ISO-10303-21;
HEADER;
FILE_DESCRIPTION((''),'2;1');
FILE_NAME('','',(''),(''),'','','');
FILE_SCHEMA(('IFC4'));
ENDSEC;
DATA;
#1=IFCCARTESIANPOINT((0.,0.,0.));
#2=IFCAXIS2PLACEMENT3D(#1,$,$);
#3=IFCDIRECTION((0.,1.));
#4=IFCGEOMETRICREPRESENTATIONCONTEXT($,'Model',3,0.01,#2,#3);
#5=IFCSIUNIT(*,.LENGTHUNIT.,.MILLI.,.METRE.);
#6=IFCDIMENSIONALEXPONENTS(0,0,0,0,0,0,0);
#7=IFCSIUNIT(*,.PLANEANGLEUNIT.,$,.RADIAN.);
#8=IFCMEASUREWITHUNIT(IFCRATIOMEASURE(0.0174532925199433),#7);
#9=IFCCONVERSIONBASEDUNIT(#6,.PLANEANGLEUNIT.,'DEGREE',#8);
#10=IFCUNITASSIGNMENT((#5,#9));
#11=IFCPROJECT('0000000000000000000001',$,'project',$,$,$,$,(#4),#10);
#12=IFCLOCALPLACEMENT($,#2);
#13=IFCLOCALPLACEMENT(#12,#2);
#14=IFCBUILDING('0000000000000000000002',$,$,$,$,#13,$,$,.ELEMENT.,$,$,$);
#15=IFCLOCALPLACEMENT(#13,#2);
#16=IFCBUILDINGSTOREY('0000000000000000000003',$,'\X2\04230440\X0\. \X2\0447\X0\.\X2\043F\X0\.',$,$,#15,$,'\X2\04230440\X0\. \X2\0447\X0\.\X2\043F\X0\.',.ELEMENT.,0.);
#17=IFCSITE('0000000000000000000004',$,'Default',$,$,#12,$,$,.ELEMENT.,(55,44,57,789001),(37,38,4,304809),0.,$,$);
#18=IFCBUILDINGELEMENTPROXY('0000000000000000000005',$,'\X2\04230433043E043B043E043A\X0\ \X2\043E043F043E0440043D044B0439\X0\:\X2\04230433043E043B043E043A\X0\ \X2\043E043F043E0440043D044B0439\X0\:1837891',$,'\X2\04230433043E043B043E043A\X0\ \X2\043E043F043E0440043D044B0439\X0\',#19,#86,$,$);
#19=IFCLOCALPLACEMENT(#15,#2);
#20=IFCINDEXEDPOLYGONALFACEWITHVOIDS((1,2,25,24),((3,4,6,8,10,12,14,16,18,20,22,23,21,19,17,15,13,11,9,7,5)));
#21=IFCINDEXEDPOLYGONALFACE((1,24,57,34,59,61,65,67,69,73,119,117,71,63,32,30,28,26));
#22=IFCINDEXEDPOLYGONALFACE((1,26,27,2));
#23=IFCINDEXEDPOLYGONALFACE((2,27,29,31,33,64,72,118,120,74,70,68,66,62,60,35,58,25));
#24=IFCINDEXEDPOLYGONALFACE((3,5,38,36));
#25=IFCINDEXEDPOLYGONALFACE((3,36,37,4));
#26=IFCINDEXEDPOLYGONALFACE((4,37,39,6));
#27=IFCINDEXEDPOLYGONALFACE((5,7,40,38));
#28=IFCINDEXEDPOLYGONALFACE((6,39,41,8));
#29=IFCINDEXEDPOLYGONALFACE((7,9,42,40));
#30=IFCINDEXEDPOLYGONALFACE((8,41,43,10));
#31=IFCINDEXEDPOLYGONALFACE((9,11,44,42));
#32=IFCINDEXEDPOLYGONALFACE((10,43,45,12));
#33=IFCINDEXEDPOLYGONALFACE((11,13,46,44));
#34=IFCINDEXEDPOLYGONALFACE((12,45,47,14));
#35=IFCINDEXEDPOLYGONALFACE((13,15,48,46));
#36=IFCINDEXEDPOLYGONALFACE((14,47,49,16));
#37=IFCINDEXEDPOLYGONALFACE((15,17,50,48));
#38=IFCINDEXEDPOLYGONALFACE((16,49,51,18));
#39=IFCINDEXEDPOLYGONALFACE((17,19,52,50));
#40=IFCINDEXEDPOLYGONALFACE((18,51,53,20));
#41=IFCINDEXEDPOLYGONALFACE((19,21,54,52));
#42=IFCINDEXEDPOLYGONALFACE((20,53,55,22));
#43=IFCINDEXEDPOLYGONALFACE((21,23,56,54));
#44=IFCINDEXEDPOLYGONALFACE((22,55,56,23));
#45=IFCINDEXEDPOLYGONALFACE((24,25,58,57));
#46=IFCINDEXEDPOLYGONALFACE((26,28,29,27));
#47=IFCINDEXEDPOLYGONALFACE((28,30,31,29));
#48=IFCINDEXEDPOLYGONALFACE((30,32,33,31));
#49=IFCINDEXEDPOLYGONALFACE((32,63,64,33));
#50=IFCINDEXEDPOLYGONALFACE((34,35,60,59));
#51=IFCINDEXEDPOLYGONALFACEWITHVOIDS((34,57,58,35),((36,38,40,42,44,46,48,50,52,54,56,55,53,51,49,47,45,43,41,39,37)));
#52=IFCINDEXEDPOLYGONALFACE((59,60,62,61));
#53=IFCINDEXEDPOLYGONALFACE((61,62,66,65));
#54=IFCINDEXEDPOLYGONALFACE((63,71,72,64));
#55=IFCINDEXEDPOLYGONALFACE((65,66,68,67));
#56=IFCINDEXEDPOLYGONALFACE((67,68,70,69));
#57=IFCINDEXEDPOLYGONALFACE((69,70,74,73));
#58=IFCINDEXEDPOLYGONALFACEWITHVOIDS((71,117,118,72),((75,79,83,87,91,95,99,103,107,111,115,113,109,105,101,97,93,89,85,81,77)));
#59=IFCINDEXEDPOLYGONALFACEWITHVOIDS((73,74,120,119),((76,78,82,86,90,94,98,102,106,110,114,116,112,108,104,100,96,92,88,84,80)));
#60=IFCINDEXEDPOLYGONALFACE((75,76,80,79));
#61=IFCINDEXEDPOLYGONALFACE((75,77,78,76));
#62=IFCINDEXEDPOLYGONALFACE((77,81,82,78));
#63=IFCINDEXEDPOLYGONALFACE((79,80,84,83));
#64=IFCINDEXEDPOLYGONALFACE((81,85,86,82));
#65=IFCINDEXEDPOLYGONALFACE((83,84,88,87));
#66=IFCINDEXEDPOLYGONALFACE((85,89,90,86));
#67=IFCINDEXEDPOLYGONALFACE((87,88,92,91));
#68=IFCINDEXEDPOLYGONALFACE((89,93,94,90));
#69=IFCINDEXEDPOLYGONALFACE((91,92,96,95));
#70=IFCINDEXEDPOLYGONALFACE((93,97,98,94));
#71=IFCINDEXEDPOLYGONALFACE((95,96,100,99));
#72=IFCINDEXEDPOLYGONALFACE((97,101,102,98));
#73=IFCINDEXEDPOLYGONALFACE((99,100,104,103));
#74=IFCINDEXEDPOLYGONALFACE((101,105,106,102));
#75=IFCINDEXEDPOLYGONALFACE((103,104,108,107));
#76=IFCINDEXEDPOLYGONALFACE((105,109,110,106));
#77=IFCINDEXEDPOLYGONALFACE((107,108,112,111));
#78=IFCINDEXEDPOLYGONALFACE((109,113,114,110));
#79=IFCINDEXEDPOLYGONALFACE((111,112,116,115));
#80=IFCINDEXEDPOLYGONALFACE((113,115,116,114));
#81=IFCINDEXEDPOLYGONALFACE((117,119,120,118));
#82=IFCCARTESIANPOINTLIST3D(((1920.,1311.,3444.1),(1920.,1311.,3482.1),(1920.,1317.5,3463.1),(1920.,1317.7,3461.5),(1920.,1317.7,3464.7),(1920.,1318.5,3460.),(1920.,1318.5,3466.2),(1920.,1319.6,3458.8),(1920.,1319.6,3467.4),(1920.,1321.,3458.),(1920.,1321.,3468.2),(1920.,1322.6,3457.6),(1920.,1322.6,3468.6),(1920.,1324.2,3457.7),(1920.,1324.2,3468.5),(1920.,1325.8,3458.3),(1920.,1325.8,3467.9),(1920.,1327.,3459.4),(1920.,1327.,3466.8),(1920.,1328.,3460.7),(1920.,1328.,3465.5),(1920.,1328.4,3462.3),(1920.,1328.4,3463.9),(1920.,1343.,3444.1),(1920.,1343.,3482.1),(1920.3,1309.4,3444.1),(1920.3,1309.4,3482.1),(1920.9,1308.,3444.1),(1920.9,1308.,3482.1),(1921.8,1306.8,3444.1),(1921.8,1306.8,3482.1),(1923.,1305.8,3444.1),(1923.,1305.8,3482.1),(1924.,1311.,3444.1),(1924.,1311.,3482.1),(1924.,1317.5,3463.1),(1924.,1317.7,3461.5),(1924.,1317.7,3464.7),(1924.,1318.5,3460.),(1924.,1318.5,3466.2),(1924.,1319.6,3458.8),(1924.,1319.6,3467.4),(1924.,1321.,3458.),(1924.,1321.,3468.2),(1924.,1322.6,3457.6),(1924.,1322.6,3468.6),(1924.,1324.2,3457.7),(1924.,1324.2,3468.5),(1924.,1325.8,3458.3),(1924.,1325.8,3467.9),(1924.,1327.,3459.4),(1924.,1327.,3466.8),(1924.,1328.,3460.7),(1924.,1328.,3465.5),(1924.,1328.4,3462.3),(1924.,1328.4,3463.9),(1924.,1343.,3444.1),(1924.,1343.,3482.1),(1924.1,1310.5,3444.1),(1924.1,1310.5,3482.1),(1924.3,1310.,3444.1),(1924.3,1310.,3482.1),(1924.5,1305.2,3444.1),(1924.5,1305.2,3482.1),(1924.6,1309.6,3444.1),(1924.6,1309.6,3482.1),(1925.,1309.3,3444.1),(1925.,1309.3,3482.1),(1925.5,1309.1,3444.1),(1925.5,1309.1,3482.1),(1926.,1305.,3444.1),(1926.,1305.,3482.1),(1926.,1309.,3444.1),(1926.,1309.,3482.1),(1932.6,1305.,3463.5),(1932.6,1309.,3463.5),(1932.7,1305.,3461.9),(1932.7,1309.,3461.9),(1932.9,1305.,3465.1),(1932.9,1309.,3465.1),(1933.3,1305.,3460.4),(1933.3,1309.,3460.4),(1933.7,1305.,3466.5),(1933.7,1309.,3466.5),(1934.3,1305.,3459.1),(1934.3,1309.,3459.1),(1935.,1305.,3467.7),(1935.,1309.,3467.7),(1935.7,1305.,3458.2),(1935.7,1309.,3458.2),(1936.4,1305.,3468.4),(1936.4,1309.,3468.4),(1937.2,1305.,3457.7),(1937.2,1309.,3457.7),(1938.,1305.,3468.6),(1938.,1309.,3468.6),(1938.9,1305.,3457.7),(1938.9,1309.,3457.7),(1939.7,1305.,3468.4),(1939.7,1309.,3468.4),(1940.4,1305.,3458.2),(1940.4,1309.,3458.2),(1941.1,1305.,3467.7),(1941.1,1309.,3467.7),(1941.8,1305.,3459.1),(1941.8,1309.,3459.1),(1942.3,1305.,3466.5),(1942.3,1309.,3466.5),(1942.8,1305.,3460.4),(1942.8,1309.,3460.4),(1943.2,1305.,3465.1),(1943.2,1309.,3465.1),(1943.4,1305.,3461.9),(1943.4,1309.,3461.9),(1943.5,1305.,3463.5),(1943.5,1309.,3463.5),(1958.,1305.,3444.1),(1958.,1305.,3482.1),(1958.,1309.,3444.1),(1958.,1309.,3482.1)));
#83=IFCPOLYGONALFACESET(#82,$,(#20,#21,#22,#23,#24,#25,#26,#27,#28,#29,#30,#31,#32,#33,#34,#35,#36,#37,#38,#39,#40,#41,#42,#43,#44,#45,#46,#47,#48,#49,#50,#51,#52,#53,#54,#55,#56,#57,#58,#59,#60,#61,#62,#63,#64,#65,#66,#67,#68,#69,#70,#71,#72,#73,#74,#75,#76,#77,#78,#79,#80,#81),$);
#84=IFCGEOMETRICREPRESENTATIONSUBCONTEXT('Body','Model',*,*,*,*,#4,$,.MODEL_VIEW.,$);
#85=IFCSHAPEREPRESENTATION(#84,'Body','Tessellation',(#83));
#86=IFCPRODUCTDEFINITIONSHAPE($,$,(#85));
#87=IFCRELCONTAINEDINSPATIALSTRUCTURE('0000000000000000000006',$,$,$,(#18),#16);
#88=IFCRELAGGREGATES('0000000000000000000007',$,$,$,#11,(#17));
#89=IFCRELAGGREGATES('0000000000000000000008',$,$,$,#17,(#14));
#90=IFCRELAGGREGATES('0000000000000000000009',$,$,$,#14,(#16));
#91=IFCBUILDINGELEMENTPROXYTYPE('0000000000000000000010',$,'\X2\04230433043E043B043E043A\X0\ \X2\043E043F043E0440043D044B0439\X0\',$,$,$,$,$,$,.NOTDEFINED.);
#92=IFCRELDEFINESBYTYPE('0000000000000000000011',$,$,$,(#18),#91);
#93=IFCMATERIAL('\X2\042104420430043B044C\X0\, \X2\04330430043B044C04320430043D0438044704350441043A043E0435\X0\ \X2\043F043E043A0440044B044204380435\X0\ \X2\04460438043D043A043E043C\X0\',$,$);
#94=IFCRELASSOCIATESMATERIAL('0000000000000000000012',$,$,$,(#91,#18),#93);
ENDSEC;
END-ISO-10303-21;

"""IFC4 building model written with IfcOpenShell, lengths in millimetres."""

from ifc_helpers import new_model, entity, si_unit, converted_unit, direction, frame, frame_2d, origin, place, context, subcontext, project, spatial, polyline, circle_curve, parameter, trimmed, segment, composite_curve, circle, outline, extrude, source, transform, mapped, material, type_object, type_shapes, element, save


model = new_model("IFC4")

# Units and contexts
model_context = context("Model", 3, precision=0.01, world=origin(), true_north=direction((0.0, 1.0)))
body_context = subcontext(model_context, "Body", "Model", "MODEL_VIEW")
ifc_project = project(units=[si_unit("LENGTHUNIT", "METRE", prefix="MILLI"), converted_unit("PLANEANGLEUNIT", "DEGREE", entity("IfcRatioMeasure", 0.0174532925199433), si_unit("PLANEANGLEUNIT", "RADIAN"), dimensions=[0, 0, 0, 0, 0, 0, 0])], contexts=[model_context])

# Site, building, storey
site_placement = place(None, origin())
site = spatial("IfcSite", under=ifc_project, at=site_placement, Name="Default", CompositionType="ELEMENT", RefLatitude=(55, 44, 57, 789001), RefLongitude=(37, 38, 4, 304809), RefElevation=0.0)
building_placement = place(site_placement, origin())
building = spatial("IfcBuilding", under=site, at=building_placement, CompositionType="ELEMENT")
storey_placement = place(building_placement, origin())
storey = spatial("IfcBuildingStorey", under=building, at=storey_placement, Name="Ур. ч.п.", LongName="Ур. ч.п.", CompositionType="ELEMENT", Elevation=0.0)

# Building element proxy, openings
ifc_material_1 = material(Name="Сталь, гальваническое покрытие цинком")
building_element_proxy_type_1 = type_object("IfcBuildingElementProxyType", Name="Уголок опорный", material=ifc_material_1)
shared_shape_1 = source(origin(), body_context, "Body", "SweptSolid", [
    extrude(outline(composite_curve([segment(polyline([(-6.0, -12.0), (26.0, -12.0)]), True, "CONTINUOUS"), segment(polyline([(26.0, -12.0), (26.0, -8.0)]), True, "CONTINUOUS"), segment(polyline([(26.0, -8.0), (-6.0, -8.0)]), True, "CONTINUOUS"), segment(trimmed(circle_curve(frame_2d((-6.0, -6.0), x_axis=(0.0, -1.0)), 2.0), [parameter(270.0)], [parameter(0.0)], True, "PARAMETER"), False, "CONTINUOUS"), segment(polyline([(-8.0, -6.0), (-8.0, 26.0)]), True, "CONTINUOUS"), segment(polyline([(-8.0, 26.0), (-12.0, 26.0)]), True, "CONTINUOUS"), segment(polyline([(-12.0, 26.0), (-12.0, -6.0)]), True, "CONTINUOUS"), segment(trimmed(circle_curve(frame_2d((-6.0, -6.0), x_axis=(0.0, -1.0)), 6.0), [parameter(270.0)], [parameter(360.0)], True, "PARAMETER"), True, "CONTINUOUS")], self_intersect=False)), frame((12.0, -19.0, 12.0), z_axis=(0.0, 1.0, 0.0), x_axis=(0.0, 0.0, 1.0)), (0.0, 0.0, 1.0), 38.0),
])
type_shapes(building_element_proxy_type_1, [shared_shape_1])
proxy_1_placement = place(storey_placement, frame((1920.0, 1305.0, 3463.1), z_axis=(0.0, 1.0, 0.0), x_axis=(1.0, 0.0, 0.0)))
proxy_1 = element("IfcBuildingElementProxy", 1, at=proxy_1_placement, inside=storey, type_object=building_element_proxy_type_1, material=ifc_material_1, Name="Уголок опорный:Уголок опорный:1837891", ObjectType="Уголок опорный", context=body_context, shape_type="MappedRepresentation", body=[
    mapped(shared_shape_1, transform((0.0, 0.0, 0.0), scale=1.0)),
])
opening_1_placement = place(storey_placement, frame((1920.0, 1305.0, 3463.1), z_axis=(0.0, 0.0, -1.0), x_axis=(1.0, 0.0, 0.0)))
element("IfcOpeningElement", 2, at=opening_1_placement, cuts=proxy_1, ObjectType="Opening", PredefinedType="OPENING", context=body_context, shape_type="SweptSolid", body=[
    extrude(circle(Radius=5.5, at=frame_2d((0.0, 0.0), x_axis=(1.0, 0.0))), frame((4.0, -18.0, 0.0), z_axis=(-1.0, 0.0, 0.0), x_axis=(0.0, 1.0, 0.0)), (0.0, 0.0, 1.0), 4.0),
])
opening_2_placement = place(storey_placement, frame((1920.0, 1305.0, 3463.1), z_axis=(0.0, 0.0, -1.0), x_axis=(1.0, 0.0, 0.0)))
element("IfcOpeningElement", 3, at=opening_2_placement, cuts=proxy_1, ObjectType="Opening", PredefinedType="OPENING", context=body_context, shape_type="SweptSolid", body=[
    extrude(circle(Radius=5.5, at=frame_2d((0.0, 0.0), x_axis=(1.0, 0.0))), frame((18.0, 0.0, 0.0), z_axis=(0.0, -1.0, 0.0), x_axis=(0.0, 0.0, -1.0)), (0.0, 0.0, 1.0), 4.0),
])

save(model, "model.ifc")
